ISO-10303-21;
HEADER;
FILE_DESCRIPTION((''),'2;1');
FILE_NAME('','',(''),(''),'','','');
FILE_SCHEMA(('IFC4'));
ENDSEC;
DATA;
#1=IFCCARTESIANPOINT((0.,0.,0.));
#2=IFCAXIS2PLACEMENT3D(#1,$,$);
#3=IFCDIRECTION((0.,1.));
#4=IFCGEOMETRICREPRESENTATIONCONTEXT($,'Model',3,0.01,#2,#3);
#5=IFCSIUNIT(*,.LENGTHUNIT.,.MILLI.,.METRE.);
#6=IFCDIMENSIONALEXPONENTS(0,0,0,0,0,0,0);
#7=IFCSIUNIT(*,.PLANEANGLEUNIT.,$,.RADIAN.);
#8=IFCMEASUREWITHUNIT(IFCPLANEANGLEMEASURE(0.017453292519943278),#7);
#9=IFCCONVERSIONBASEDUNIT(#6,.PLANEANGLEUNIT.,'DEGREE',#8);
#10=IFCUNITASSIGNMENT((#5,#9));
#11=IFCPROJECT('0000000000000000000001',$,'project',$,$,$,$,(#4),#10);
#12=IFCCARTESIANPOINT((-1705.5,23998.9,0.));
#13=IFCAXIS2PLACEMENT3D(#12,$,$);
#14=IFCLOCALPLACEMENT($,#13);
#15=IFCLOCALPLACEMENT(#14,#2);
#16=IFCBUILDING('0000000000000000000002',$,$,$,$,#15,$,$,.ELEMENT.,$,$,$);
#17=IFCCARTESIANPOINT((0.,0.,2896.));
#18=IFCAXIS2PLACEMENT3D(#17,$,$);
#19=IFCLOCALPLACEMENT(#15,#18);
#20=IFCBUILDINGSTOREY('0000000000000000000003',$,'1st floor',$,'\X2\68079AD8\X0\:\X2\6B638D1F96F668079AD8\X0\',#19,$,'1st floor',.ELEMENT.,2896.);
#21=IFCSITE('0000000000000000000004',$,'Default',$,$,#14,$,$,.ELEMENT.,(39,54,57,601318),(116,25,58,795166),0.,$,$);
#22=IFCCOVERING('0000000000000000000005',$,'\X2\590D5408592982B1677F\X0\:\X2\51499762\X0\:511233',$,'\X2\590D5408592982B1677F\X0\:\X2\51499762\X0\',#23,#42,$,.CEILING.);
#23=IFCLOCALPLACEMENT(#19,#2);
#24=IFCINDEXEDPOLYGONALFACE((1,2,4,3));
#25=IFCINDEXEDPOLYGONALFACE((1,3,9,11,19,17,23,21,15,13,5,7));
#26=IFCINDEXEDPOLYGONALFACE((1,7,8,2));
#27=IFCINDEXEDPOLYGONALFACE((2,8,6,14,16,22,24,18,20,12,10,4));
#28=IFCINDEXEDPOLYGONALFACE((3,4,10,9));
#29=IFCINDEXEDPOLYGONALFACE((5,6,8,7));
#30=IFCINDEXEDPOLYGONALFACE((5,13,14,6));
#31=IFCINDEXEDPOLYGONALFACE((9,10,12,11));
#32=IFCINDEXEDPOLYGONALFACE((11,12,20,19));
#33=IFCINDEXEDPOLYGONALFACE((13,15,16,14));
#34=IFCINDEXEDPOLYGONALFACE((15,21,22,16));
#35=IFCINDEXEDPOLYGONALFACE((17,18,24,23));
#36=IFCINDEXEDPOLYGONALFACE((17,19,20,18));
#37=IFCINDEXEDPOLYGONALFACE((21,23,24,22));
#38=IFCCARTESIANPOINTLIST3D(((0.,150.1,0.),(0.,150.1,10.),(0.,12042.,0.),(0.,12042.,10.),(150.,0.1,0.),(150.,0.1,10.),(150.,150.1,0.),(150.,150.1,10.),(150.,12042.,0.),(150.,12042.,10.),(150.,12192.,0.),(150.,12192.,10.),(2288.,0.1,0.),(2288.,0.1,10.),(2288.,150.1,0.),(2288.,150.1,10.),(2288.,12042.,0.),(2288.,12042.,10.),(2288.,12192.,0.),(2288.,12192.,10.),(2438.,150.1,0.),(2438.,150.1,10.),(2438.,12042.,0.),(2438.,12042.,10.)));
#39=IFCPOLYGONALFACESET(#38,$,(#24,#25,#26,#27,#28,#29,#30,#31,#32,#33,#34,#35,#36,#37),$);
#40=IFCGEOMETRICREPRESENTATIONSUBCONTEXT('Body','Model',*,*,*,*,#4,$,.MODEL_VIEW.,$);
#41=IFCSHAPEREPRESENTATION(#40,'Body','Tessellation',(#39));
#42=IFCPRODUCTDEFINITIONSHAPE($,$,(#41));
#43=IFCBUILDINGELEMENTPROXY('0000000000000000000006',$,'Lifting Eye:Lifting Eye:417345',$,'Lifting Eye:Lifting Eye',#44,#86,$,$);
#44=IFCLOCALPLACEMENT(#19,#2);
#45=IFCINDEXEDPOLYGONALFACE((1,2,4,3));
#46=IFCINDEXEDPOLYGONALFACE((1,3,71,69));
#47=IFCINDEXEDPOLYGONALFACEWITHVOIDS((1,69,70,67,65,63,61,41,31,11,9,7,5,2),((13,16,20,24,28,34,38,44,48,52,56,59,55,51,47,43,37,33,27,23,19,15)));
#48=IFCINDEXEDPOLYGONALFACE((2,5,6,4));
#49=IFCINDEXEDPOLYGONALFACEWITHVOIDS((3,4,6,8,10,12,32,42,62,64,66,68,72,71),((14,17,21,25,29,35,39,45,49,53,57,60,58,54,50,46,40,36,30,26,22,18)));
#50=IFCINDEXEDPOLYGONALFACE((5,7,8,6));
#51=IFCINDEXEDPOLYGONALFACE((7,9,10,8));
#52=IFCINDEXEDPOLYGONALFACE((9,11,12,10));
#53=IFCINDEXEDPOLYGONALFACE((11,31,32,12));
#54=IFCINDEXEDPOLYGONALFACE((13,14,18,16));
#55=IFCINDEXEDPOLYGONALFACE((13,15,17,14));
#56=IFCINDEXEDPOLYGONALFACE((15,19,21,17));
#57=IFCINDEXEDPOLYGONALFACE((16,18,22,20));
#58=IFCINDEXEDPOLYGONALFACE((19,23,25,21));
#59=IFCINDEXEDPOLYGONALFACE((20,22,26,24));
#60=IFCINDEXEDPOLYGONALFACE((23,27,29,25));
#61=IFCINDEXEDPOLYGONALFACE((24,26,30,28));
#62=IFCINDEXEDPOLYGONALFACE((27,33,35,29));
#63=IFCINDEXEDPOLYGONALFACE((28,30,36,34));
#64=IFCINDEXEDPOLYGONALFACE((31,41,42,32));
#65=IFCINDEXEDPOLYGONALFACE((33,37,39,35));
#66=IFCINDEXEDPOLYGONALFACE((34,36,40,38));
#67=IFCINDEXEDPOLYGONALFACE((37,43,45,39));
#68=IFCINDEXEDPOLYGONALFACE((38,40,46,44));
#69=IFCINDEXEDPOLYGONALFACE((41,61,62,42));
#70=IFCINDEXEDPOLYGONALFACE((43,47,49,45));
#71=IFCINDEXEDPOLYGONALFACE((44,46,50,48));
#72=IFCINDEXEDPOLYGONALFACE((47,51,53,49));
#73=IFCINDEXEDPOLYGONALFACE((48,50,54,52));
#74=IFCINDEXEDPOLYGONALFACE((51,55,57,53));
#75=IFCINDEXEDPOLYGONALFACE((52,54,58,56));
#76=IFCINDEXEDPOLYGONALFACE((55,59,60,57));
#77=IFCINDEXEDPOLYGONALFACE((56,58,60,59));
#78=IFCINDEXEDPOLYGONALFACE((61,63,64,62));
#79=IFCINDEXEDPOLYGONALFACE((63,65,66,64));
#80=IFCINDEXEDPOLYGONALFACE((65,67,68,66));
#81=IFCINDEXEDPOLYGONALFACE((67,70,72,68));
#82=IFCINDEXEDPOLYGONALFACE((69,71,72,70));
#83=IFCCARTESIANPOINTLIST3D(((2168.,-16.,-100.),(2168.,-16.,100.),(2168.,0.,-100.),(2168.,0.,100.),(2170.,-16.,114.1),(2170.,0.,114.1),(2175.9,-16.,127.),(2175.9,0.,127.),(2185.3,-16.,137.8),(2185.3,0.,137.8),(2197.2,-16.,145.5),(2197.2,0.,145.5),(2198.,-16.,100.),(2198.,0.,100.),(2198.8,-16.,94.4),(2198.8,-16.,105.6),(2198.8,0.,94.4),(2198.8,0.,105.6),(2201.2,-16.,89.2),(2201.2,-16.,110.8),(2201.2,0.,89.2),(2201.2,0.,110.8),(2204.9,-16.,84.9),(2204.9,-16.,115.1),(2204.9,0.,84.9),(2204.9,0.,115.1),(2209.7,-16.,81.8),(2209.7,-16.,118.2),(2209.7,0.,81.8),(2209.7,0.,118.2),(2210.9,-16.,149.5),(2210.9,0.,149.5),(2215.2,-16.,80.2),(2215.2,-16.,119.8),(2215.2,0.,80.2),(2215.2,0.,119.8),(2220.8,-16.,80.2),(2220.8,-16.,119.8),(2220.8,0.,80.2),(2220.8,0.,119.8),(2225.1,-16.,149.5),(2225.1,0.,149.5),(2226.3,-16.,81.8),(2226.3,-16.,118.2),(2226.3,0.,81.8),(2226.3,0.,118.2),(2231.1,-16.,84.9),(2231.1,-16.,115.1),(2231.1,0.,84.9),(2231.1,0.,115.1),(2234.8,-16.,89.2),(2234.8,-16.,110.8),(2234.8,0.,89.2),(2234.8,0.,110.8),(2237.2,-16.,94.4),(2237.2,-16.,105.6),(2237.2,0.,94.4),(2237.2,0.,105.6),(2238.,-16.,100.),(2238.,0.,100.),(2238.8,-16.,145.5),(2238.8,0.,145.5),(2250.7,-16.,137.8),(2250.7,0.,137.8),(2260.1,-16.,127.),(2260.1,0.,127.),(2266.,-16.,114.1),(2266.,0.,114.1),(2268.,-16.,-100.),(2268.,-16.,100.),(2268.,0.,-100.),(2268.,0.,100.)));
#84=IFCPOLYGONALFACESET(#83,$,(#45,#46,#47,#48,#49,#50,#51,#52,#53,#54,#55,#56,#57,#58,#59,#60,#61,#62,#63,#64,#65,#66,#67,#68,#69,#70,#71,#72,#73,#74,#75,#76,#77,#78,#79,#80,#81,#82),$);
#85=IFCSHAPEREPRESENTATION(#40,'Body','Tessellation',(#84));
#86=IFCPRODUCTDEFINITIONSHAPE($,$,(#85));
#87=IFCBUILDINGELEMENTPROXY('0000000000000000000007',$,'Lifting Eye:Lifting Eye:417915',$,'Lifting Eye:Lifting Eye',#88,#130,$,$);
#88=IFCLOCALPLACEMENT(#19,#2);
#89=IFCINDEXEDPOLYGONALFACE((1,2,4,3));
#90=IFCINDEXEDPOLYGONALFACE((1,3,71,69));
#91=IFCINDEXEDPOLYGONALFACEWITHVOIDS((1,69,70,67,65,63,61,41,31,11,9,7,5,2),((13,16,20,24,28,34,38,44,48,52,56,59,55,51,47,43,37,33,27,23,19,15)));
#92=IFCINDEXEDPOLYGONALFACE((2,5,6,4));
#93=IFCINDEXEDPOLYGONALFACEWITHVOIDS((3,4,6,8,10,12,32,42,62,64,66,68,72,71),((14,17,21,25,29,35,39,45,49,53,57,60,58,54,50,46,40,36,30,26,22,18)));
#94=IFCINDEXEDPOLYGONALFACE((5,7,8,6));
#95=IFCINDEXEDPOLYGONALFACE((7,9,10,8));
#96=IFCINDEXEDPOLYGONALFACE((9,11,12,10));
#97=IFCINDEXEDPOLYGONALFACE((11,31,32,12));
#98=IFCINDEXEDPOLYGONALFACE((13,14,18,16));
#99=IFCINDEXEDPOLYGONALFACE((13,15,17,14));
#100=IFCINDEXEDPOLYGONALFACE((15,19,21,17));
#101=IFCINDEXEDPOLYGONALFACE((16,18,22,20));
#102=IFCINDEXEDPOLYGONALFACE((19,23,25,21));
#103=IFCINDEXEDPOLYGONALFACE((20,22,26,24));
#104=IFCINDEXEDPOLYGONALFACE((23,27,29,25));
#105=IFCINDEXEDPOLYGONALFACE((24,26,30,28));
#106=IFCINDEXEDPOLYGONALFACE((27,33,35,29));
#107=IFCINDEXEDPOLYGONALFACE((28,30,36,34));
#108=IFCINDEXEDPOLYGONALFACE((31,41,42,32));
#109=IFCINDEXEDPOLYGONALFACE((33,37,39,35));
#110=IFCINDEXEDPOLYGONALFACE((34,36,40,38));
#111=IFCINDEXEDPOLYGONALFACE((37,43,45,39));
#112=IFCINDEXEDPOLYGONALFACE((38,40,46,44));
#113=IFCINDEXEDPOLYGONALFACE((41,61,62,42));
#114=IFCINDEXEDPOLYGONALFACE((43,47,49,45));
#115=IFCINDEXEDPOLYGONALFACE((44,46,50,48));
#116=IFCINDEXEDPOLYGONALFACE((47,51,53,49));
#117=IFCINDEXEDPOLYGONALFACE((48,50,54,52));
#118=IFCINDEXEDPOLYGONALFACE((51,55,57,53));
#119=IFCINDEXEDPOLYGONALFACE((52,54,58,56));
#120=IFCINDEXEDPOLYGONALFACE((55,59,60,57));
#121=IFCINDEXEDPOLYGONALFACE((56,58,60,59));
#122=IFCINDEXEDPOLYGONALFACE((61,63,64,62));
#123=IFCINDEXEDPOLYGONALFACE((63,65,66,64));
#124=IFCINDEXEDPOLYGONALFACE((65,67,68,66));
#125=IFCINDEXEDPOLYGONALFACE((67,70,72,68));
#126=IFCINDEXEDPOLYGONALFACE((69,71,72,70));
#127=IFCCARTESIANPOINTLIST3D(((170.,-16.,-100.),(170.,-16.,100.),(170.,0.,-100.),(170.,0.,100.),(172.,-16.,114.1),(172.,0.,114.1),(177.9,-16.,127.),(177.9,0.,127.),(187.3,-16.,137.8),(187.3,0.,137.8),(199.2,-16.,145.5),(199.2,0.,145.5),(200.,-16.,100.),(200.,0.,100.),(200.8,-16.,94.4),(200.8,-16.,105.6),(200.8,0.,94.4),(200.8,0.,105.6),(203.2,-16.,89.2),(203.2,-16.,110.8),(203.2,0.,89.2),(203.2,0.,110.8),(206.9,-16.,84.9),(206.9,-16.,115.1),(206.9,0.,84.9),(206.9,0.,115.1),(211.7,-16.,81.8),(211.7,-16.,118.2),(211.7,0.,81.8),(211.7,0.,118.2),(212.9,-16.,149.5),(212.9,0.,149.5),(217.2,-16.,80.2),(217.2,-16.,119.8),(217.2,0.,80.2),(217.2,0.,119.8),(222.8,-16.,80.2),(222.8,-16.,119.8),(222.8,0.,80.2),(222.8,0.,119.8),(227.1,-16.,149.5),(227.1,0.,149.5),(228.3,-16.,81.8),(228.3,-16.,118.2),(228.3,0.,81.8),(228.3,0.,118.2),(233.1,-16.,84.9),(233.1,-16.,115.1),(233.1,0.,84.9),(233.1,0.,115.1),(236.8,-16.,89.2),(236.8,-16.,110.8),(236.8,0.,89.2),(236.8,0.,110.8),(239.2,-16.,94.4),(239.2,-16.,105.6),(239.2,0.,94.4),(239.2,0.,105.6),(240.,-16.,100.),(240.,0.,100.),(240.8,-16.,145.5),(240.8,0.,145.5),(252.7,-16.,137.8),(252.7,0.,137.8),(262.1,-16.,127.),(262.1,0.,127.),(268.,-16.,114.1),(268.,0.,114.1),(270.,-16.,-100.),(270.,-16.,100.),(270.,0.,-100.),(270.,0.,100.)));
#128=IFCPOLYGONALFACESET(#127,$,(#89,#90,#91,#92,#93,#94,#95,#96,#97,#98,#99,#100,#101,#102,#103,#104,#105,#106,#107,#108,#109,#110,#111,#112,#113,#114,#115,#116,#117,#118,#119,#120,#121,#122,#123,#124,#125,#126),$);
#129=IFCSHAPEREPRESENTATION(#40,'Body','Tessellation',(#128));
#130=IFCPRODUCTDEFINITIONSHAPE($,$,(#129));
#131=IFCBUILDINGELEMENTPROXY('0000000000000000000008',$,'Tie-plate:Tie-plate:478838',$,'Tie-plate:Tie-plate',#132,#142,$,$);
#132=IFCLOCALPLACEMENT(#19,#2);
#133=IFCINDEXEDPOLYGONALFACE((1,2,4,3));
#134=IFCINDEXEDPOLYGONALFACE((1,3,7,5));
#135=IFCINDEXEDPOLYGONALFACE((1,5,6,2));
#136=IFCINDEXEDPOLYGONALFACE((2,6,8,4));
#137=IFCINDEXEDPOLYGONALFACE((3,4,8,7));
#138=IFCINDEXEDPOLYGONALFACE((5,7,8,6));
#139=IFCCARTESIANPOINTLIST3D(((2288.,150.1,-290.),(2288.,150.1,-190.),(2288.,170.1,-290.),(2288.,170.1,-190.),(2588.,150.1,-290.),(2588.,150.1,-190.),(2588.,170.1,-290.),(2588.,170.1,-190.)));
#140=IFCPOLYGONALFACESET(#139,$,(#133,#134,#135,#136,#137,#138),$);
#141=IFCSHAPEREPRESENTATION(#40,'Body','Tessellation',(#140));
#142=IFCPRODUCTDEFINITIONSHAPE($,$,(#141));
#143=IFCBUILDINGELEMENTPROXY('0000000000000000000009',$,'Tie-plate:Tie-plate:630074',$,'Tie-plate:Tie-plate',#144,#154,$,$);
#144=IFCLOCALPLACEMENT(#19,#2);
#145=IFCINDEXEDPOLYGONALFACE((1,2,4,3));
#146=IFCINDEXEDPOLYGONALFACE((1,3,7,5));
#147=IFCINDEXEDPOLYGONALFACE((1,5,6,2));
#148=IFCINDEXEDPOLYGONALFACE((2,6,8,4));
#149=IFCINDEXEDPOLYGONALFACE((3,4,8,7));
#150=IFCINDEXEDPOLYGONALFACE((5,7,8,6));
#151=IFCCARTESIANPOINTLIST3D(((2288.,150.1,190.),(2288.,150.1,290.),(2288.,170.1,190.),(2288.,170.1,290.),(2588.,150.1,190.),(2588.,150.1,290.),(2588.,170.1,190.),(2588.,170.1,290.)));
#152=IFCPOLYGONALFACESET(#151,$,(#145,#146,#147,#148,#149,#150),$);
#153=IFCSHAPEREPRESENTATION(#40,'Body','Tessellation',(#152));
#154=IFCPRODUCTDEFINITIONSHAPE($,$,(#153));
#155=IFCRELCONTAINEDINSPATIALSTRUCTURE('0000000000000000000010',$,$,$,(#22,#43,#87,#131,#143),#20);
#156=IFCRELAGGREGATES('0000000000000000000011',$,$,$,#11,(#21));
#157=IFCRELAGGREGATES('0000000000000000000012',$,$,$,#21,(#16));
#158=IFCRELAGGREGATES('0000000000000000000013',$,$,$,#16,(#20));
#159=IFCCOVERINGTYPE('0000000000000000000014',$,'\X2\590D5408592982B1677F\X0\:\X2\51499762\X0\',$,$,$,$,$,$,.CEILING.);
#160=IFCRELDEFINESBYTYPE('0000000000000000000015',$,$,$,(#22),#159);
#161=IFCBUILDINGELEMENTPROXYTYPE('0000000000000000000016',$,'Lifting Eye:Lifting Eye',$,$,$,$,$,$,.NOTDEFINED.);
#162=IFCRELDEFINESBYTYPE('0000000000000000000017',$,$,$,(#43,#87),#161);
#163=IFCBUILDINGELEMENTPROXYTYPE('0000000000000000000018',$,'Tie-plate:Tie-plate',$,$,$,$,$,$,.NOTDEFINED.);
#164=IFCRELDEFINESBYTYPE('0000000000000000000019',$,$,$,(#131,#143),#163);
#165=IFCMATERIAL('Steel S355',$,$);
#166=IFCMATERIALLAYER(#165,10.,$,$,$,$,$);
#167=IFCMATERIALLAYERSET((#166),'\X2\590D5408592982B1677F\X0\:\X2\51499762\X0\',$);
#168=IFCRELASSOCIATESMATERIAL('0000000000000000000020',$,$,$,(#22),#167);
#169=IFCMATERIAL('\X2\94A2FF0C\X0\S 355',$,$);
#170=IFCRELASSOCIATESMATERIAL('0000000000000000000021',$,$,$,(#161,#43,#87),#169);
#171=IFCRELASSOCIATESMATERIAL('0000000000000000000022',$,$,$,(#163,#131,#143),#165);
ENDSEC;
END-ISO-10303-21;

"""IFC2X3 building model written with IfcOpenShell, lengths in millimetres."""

from ifc_helpers import new_model, entity, si_unit, converted_unit, direction, frame, frame_2d, origin, place, context, subcontext, project, spatial, polyline, circle_curve, parameter, trimmed, segment, composite_curve, rectangle, outline, extrude, source, transform, mapped, material, layer, layer_set, layer_usage, type_object, type_shapes, element, save


model = new_model("IFC2X3")

# Units and contexts
model_context = context("Model", 3, precision=0.01, world=origin(), true_north=direction((0.0, 1.0)))
body_context = subcontext(model_context, "Body", "Model", "MODEL_VIEW")
ifc_project = project(units=[si_unit("LENGTHUNIT", "METRE", prefix="MILLI"), converted_unit("PLANEANGLEUNIT", "DEGREE", entity("IfcPlaneAngleMeasure", 0.017453292519943278), si_unit("PLANEANGLEUNIT", "RADIAN"), dimensions=[0, 0, 0, 0, 0, 0, 0])], contexts=[model_context])

# Site, building, storey
site_placement = place(None, frame((-1705.5, 23998.9, 0.0)))
site = spatial("IfcSite", under=ifc_project, at=site_placement, Name="Default", CompositionType="ELEMENT", RefLatitude=(39, 54, 57, 601318), RefLongitude=(116, 25, 58, 795166), RefElevation=0.0)
building_placement = place(site_placement, origin())
building = spatial("IfcBuilding", under=site, at=building_placement, CompositionType="ELEMENT")
storey_placement = place(building_placement, frame((0.0, 0.0, 2896.0)))
storey = spatial("IfcBuildingStorey", under=building, at=storey_placement, Name="1st floor", ObjectType="标高:正负零标高", LongName="1st floor", CompositionType="ELEMENT", Elevation=2896.0)

# Shared definitions
ifc_material_1 = material(Name="Steel S355")

# Covering
ifc_layer_1 = layer(ifc_material_1, 10.0)
ifc_layer_set_1 = layer_set([ifc_layer_1], Name="复合天花板:光面")
ifc_layer_usage_1 = layer_usage(ifc_layer_set_1, "AXIS3", "NEGATIVE", 10.0)
covering_type = type_object("IfcCoveringType", Name="复合天花板:光面", PredefinedType="CEILING")
covering_placement = place(storey_placement, origin())
element("IfcCovering", 1, at=covering_placement, inside=storey, type_object=covering_type, material=ifc_layer_usage_1, Name="复合天花板:光面:511233", ObjectType="复合天花板:光面", PredefinedType="CEILING", context=body_context, shape_type="SweptSolid", body=[
    extrude(outline(polyline([(5946.0, -1069.0), (6096.0, -1069.0), (6096.0, 1069.0), (5945.9, 1069.0), (5945.9, 1219.0), (-5946.0, 1219.0), (-5946.0, 1069.0), (-6096.0, 1069.0), (-6096.0, -1069.0), (-5946.0, -1069.0), (-5946.0, -1219.0), (5946.0, -1219.0), (5946.0, -1069.0)])), frame((1219.0, 6096.0, 0.0), z_axis=(0.0, 0.0, 1.0), x_axis=(0.0, 1.0, 0.0)), (0.0, 0.0, 1.0), 10.0),
])

# Building element proxies
ifc_material_2 = material(Name="钢，S 355")
building_element_proxy_type_1 = type_object("IfcBuildingElementProxyType", Name="Lifting Eye:Lifting Eye", PredefinedType="NOTDEFINED", material=ifc_material_2)
shared_shape_1 = source(origin(), body_context, "Body", "SweptSolid", [
    extrude(outline(composite_curve([segment(polyline([(-100.0, -50.0), (100.0, -50.0)]), True, "CONTINUOUS"), segment(polyline([(100.0, -50.0), (100.0, 50.0)]), True, "CONTINUOUS"), segment(polyline([(100.0, 50.0), (-100.0, 50.0)]), True, "CONTINUOUS"), segment(trimmed(circle_curve(frame_2d((-100.0, 0.0), x_axis=(0.0, -1.0)), 50.0), [parameter(180.0)], [parameter(0.0)], True, "PARAMETER"), True, "CONTINUOUS")], self_intersect=False), holes=[composite_curve([segment(trimmed(circle_curve(frame_2d((-100.0, 0.0), x_axis=(0.0, -1.0)), 20.0), [parameter(180.0)], [parameter(360.0)], True, "PARAMETER"), False, "CONTINUOUS"), segment(trimmed(circle_curve(frame_2d((-100.0, 0.0), x_axis=(0.0, -1.0)), 20.0), [parameter(0.0)], [parameter(180.0)], True, "PARAMETER"), False, "CONTINUOUS")], self_intersect=False)]), frame((0.0, 17.0, -17.0), z_axis=(0.0, 1.0, 0.0), x_axis=(0.0, 0.0, -1.0)), (0.0, 0.0, 1.0), 16.0),
])
type_shapes(building_element_proxy_type_1, [shared_shape_1])
for number, where, name in (
    (2, (2218.0, -33.0, 17.0), "Lifting Eye:Lifting Eye:417345"),
    (3, (220.0, -33.0, 17.0), "Lifting Eye:Lifting Eye:417915"),
):
    element("IfcBuildingElementProxy", number, at=place(storey_placement, frame(where)), inside=storey, type_object=building_element_proxy_type_1, material=ifc_material_2, Name=name, ObjectType="Lifting Eye:Lifting Eye", context=body_context, shape_type="MappedRepresentation", body=[
        mapped(shared_shape_1, transform((0.0, 0.0, 0.0), scale=1.0)),
    ])
building_element_proxy_type_2 = type_object("IfcBuildingElementProxyType", Name="Tie-plate:Tie-plate", PredefinedType="NOTDEFINED", material=ifc_material_1)
shared_shape_2 = source(origin(), body_context, "Body", "SweptSolid", [
    extrude(rectangle(XDim=20.0, YDim=300.0, at=frame_2d((0.0, 0.0), x_axis=(1.0, 0.0))), frame((150.0, 10.0, 0.0), z_axis=(0.0, 0.0, 1.0), x_axis=(0.0, 1.0, 0.0)), (0.0, 0.0, 1.0), 100.0),
])
type_shapes(building_element_proxy_type_2, [shared_shape_2])
for number, where, name in (
    (4, (2288.0, 150.1, -290.0), "Tie-plate:Tie-plate:478838"),
    (5, (2288.0, 150.1, 190.0), "Tie-plate:Tie-plate:630074"),
):
    element("IfcBuildingElementProxy", number, at=place(storey_placement, frame(where)), inside=storey, type_object=building_element_proxy_type_2, material=ifc_material_1, Name=name, ObjectType="Tie-plate:Tie-plate", context=body_context, shape_type="MappedRepresentation", body=[
        mapped(shared_shape_2, transform((0.0, 0.0, 0.0), scale=1.0)),
    ])

save(model, "model.ifc")
